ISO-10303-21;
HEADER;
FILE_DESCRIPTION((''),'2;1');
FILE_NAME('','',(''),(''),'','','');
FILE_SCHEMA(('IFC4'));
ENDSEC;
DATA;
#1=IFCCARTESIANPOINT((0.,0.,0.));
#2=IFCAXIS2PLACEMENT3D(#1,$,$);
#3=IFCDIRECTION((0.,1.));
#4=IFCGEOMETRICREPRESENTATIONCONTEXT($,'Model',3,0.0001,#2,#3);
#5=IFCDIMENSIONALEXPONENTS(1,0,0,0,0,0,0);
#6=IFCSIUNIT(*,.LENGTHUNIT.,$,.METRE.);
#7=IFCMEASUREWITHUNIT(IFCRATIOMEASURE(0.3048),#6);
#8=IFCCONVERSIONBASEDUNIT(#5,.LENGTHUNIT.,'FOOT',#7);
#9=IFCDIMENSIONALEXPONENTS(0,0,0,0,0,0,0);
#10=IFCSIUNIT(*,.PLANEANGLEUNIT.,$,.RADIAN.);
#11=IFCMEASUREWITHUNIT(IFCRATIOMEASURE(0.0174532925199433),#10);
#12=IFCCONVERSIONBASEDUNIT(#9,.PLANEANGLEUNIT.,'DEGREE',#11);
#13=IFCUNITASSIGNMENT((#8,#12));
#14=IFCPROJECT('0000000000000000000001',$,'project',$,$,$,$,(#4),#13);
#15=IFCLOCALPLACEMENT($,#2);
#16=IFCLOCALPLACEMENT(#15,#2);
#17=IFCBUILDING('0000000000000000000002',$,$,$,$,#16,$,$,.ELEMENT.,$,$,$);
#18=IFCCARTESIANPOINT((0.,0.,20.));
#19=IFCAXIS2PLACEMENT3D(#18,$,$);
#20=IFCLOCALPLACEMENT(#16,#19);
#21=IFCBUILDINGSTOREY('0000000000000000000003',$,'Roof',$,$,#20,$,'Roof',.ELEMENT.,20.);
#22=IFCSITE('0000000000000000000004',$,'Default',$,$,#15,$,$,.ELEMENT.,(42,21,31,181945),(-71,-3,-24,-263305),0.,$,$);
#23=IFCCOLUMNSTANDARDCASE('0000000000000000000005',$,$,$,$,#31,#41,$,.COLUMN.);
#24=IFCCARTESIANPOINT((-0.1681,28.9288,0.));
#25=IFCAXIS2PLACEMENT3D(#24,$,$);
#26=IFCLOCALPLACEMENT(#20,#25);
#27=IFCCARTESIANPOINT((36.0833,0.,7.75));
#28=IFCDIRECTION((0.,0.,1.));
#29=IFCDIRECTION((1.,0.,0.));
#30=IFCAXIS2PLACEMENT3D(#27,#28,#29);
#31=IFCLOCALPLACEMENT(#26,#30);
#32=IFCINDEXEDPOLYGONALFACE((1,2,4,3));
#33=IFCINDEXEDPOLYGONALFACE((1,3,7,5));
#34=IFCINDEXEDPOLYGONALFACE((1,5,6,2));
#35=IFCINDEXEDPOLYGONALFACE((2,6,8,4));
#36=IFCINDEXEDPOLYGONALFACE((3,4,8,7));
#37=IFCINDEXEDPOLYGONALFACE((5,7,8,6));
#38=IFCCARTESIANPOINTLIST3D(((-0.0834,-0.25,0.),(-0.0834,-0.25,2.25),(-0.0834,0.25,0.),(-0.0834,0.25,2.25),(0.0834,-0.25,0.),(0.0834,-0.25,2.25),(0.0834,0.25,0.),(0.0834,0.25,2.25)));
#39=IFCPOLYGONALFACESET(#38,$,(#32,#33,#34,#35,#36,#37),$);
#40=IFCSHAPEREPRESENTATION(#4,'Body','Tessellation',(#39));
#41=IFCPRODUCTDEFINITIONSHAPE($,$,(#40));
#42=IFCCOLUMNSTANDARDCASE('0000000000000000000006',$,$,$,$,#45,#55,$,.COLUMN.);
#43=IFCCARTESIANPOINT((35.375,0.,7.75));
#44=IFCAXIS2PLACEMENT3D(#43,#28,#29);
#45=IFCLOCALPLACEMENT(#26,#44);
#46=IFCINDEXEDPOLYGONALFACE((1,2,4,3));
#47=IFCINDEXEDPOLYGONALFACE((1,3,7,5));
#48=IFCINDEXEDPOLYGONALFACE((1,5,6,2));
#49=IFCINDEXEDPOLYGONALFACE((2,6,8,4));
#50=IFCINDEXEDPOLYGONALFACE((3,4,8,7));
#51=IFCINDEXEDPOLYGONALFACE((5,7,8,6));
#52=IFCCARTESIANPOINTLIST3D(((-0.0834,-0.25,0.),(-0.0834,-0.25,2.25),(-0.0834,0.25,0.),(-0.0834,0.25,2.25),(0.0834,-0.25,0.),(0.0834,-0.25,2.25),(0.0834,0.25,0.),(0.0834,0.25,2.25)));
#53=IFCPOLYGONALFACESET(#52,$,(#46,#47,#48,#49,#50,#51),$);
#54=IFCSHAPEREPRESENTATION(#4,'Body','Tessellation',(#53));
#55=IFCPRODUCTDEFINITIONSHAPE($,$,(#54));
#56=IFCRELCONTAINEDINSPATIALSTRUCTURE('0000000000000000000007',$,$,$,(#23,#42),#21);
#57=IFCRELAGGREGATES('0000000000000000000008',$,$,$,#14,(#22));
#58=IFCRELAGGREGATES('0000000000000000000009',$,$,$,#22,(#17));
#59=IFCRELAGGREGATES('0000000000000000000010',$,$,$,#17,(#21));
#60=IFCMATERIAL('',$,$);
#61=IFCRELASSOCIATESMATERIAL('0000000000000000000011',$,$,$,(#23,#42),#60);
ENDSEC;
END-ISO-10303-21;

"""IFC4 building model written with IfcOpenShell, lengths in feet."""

from ifc_helpers import new_model, entity, si_unit, converted_unit, direction, frame, origin, place, context, project, spatial, rectangle, extrude, material, element, save


model = new_model("IFC4")

# Units and contexts
model_context = context("Model", 3, precision=0.0001, world=origin(), true_north=direction((0.0, 1.0)))
ifc_project = project(units=[converted_unit("LENGTHUNIT", "FOOT", entity("IfcRatioMeasure", 0.3048), si_unit("LENGTHUNIT", "METRE"), dimensions=[1, 0, 0, 0, 0, 0, 0]), converted_unit("PLANEANGLEUNIT", "DEGREE", entity("IfcRatioMeasure", 0.0174532925199433), si_unit("PLANEANGLEUNIT", "RADIAN"), dimensions=[0, 0, 0, 0, 0, 0, 0])], contexts=[model_context])

# Site, building, storey
site_placement = place(None, origin())
site = spatial("IfcSite", under=ifc_project, at=site_placement, Name="Default", CompositionType="ELEMENT", RefLatitude=(42, 21, 31, 181945), RefLongitude=(-71, -3, -24, -263305), RefElevation=0.0)
building_placement = place(site_placement, origin())
building = spatial("IfcBuilding", under=site, at=building_placement, CompositionType="ELEMENT")
storey_placement = place(building_placement, frame((0.0, 0.0, 20.0)))
storey = spatial("IfcBuildingStorey", under=building, at=storey_placement, Name="Roof", LongName="Roof", CompositionType="ELEMENT", Elevation=20.0)

# Columns
ifc_material = material(Name="")
placement = place(storey_placement, frame((-0.1681, 28.9288, 0.0)))
for number, where, z_axis, x_axis in (
    (1, (36.0833, 0.0, 7.75), (0.0, 0.0, 1.0), (1.0, 0.0, 0.0)),
    (2, (35.375, 0.0, 7.75), (0.0, 0.0, 1.0), (1.0, 0.0, 0.0)),
):
    element("IfcColumnStandardCase", number, at=place(placement, frame(where, z_axis=z_axis, x_axis=x_axis)), inside=storey, material=ifc_material, PredefinedType="COLUMN", context=model_context, shape_type="SweptSolid", body=[
        extrude(rectangle(XDim=0.1667, YDim=0.5), origin(), (0.0, 0.0, 1.0), 2.25),
    ])

save(model, "model.ifc")
